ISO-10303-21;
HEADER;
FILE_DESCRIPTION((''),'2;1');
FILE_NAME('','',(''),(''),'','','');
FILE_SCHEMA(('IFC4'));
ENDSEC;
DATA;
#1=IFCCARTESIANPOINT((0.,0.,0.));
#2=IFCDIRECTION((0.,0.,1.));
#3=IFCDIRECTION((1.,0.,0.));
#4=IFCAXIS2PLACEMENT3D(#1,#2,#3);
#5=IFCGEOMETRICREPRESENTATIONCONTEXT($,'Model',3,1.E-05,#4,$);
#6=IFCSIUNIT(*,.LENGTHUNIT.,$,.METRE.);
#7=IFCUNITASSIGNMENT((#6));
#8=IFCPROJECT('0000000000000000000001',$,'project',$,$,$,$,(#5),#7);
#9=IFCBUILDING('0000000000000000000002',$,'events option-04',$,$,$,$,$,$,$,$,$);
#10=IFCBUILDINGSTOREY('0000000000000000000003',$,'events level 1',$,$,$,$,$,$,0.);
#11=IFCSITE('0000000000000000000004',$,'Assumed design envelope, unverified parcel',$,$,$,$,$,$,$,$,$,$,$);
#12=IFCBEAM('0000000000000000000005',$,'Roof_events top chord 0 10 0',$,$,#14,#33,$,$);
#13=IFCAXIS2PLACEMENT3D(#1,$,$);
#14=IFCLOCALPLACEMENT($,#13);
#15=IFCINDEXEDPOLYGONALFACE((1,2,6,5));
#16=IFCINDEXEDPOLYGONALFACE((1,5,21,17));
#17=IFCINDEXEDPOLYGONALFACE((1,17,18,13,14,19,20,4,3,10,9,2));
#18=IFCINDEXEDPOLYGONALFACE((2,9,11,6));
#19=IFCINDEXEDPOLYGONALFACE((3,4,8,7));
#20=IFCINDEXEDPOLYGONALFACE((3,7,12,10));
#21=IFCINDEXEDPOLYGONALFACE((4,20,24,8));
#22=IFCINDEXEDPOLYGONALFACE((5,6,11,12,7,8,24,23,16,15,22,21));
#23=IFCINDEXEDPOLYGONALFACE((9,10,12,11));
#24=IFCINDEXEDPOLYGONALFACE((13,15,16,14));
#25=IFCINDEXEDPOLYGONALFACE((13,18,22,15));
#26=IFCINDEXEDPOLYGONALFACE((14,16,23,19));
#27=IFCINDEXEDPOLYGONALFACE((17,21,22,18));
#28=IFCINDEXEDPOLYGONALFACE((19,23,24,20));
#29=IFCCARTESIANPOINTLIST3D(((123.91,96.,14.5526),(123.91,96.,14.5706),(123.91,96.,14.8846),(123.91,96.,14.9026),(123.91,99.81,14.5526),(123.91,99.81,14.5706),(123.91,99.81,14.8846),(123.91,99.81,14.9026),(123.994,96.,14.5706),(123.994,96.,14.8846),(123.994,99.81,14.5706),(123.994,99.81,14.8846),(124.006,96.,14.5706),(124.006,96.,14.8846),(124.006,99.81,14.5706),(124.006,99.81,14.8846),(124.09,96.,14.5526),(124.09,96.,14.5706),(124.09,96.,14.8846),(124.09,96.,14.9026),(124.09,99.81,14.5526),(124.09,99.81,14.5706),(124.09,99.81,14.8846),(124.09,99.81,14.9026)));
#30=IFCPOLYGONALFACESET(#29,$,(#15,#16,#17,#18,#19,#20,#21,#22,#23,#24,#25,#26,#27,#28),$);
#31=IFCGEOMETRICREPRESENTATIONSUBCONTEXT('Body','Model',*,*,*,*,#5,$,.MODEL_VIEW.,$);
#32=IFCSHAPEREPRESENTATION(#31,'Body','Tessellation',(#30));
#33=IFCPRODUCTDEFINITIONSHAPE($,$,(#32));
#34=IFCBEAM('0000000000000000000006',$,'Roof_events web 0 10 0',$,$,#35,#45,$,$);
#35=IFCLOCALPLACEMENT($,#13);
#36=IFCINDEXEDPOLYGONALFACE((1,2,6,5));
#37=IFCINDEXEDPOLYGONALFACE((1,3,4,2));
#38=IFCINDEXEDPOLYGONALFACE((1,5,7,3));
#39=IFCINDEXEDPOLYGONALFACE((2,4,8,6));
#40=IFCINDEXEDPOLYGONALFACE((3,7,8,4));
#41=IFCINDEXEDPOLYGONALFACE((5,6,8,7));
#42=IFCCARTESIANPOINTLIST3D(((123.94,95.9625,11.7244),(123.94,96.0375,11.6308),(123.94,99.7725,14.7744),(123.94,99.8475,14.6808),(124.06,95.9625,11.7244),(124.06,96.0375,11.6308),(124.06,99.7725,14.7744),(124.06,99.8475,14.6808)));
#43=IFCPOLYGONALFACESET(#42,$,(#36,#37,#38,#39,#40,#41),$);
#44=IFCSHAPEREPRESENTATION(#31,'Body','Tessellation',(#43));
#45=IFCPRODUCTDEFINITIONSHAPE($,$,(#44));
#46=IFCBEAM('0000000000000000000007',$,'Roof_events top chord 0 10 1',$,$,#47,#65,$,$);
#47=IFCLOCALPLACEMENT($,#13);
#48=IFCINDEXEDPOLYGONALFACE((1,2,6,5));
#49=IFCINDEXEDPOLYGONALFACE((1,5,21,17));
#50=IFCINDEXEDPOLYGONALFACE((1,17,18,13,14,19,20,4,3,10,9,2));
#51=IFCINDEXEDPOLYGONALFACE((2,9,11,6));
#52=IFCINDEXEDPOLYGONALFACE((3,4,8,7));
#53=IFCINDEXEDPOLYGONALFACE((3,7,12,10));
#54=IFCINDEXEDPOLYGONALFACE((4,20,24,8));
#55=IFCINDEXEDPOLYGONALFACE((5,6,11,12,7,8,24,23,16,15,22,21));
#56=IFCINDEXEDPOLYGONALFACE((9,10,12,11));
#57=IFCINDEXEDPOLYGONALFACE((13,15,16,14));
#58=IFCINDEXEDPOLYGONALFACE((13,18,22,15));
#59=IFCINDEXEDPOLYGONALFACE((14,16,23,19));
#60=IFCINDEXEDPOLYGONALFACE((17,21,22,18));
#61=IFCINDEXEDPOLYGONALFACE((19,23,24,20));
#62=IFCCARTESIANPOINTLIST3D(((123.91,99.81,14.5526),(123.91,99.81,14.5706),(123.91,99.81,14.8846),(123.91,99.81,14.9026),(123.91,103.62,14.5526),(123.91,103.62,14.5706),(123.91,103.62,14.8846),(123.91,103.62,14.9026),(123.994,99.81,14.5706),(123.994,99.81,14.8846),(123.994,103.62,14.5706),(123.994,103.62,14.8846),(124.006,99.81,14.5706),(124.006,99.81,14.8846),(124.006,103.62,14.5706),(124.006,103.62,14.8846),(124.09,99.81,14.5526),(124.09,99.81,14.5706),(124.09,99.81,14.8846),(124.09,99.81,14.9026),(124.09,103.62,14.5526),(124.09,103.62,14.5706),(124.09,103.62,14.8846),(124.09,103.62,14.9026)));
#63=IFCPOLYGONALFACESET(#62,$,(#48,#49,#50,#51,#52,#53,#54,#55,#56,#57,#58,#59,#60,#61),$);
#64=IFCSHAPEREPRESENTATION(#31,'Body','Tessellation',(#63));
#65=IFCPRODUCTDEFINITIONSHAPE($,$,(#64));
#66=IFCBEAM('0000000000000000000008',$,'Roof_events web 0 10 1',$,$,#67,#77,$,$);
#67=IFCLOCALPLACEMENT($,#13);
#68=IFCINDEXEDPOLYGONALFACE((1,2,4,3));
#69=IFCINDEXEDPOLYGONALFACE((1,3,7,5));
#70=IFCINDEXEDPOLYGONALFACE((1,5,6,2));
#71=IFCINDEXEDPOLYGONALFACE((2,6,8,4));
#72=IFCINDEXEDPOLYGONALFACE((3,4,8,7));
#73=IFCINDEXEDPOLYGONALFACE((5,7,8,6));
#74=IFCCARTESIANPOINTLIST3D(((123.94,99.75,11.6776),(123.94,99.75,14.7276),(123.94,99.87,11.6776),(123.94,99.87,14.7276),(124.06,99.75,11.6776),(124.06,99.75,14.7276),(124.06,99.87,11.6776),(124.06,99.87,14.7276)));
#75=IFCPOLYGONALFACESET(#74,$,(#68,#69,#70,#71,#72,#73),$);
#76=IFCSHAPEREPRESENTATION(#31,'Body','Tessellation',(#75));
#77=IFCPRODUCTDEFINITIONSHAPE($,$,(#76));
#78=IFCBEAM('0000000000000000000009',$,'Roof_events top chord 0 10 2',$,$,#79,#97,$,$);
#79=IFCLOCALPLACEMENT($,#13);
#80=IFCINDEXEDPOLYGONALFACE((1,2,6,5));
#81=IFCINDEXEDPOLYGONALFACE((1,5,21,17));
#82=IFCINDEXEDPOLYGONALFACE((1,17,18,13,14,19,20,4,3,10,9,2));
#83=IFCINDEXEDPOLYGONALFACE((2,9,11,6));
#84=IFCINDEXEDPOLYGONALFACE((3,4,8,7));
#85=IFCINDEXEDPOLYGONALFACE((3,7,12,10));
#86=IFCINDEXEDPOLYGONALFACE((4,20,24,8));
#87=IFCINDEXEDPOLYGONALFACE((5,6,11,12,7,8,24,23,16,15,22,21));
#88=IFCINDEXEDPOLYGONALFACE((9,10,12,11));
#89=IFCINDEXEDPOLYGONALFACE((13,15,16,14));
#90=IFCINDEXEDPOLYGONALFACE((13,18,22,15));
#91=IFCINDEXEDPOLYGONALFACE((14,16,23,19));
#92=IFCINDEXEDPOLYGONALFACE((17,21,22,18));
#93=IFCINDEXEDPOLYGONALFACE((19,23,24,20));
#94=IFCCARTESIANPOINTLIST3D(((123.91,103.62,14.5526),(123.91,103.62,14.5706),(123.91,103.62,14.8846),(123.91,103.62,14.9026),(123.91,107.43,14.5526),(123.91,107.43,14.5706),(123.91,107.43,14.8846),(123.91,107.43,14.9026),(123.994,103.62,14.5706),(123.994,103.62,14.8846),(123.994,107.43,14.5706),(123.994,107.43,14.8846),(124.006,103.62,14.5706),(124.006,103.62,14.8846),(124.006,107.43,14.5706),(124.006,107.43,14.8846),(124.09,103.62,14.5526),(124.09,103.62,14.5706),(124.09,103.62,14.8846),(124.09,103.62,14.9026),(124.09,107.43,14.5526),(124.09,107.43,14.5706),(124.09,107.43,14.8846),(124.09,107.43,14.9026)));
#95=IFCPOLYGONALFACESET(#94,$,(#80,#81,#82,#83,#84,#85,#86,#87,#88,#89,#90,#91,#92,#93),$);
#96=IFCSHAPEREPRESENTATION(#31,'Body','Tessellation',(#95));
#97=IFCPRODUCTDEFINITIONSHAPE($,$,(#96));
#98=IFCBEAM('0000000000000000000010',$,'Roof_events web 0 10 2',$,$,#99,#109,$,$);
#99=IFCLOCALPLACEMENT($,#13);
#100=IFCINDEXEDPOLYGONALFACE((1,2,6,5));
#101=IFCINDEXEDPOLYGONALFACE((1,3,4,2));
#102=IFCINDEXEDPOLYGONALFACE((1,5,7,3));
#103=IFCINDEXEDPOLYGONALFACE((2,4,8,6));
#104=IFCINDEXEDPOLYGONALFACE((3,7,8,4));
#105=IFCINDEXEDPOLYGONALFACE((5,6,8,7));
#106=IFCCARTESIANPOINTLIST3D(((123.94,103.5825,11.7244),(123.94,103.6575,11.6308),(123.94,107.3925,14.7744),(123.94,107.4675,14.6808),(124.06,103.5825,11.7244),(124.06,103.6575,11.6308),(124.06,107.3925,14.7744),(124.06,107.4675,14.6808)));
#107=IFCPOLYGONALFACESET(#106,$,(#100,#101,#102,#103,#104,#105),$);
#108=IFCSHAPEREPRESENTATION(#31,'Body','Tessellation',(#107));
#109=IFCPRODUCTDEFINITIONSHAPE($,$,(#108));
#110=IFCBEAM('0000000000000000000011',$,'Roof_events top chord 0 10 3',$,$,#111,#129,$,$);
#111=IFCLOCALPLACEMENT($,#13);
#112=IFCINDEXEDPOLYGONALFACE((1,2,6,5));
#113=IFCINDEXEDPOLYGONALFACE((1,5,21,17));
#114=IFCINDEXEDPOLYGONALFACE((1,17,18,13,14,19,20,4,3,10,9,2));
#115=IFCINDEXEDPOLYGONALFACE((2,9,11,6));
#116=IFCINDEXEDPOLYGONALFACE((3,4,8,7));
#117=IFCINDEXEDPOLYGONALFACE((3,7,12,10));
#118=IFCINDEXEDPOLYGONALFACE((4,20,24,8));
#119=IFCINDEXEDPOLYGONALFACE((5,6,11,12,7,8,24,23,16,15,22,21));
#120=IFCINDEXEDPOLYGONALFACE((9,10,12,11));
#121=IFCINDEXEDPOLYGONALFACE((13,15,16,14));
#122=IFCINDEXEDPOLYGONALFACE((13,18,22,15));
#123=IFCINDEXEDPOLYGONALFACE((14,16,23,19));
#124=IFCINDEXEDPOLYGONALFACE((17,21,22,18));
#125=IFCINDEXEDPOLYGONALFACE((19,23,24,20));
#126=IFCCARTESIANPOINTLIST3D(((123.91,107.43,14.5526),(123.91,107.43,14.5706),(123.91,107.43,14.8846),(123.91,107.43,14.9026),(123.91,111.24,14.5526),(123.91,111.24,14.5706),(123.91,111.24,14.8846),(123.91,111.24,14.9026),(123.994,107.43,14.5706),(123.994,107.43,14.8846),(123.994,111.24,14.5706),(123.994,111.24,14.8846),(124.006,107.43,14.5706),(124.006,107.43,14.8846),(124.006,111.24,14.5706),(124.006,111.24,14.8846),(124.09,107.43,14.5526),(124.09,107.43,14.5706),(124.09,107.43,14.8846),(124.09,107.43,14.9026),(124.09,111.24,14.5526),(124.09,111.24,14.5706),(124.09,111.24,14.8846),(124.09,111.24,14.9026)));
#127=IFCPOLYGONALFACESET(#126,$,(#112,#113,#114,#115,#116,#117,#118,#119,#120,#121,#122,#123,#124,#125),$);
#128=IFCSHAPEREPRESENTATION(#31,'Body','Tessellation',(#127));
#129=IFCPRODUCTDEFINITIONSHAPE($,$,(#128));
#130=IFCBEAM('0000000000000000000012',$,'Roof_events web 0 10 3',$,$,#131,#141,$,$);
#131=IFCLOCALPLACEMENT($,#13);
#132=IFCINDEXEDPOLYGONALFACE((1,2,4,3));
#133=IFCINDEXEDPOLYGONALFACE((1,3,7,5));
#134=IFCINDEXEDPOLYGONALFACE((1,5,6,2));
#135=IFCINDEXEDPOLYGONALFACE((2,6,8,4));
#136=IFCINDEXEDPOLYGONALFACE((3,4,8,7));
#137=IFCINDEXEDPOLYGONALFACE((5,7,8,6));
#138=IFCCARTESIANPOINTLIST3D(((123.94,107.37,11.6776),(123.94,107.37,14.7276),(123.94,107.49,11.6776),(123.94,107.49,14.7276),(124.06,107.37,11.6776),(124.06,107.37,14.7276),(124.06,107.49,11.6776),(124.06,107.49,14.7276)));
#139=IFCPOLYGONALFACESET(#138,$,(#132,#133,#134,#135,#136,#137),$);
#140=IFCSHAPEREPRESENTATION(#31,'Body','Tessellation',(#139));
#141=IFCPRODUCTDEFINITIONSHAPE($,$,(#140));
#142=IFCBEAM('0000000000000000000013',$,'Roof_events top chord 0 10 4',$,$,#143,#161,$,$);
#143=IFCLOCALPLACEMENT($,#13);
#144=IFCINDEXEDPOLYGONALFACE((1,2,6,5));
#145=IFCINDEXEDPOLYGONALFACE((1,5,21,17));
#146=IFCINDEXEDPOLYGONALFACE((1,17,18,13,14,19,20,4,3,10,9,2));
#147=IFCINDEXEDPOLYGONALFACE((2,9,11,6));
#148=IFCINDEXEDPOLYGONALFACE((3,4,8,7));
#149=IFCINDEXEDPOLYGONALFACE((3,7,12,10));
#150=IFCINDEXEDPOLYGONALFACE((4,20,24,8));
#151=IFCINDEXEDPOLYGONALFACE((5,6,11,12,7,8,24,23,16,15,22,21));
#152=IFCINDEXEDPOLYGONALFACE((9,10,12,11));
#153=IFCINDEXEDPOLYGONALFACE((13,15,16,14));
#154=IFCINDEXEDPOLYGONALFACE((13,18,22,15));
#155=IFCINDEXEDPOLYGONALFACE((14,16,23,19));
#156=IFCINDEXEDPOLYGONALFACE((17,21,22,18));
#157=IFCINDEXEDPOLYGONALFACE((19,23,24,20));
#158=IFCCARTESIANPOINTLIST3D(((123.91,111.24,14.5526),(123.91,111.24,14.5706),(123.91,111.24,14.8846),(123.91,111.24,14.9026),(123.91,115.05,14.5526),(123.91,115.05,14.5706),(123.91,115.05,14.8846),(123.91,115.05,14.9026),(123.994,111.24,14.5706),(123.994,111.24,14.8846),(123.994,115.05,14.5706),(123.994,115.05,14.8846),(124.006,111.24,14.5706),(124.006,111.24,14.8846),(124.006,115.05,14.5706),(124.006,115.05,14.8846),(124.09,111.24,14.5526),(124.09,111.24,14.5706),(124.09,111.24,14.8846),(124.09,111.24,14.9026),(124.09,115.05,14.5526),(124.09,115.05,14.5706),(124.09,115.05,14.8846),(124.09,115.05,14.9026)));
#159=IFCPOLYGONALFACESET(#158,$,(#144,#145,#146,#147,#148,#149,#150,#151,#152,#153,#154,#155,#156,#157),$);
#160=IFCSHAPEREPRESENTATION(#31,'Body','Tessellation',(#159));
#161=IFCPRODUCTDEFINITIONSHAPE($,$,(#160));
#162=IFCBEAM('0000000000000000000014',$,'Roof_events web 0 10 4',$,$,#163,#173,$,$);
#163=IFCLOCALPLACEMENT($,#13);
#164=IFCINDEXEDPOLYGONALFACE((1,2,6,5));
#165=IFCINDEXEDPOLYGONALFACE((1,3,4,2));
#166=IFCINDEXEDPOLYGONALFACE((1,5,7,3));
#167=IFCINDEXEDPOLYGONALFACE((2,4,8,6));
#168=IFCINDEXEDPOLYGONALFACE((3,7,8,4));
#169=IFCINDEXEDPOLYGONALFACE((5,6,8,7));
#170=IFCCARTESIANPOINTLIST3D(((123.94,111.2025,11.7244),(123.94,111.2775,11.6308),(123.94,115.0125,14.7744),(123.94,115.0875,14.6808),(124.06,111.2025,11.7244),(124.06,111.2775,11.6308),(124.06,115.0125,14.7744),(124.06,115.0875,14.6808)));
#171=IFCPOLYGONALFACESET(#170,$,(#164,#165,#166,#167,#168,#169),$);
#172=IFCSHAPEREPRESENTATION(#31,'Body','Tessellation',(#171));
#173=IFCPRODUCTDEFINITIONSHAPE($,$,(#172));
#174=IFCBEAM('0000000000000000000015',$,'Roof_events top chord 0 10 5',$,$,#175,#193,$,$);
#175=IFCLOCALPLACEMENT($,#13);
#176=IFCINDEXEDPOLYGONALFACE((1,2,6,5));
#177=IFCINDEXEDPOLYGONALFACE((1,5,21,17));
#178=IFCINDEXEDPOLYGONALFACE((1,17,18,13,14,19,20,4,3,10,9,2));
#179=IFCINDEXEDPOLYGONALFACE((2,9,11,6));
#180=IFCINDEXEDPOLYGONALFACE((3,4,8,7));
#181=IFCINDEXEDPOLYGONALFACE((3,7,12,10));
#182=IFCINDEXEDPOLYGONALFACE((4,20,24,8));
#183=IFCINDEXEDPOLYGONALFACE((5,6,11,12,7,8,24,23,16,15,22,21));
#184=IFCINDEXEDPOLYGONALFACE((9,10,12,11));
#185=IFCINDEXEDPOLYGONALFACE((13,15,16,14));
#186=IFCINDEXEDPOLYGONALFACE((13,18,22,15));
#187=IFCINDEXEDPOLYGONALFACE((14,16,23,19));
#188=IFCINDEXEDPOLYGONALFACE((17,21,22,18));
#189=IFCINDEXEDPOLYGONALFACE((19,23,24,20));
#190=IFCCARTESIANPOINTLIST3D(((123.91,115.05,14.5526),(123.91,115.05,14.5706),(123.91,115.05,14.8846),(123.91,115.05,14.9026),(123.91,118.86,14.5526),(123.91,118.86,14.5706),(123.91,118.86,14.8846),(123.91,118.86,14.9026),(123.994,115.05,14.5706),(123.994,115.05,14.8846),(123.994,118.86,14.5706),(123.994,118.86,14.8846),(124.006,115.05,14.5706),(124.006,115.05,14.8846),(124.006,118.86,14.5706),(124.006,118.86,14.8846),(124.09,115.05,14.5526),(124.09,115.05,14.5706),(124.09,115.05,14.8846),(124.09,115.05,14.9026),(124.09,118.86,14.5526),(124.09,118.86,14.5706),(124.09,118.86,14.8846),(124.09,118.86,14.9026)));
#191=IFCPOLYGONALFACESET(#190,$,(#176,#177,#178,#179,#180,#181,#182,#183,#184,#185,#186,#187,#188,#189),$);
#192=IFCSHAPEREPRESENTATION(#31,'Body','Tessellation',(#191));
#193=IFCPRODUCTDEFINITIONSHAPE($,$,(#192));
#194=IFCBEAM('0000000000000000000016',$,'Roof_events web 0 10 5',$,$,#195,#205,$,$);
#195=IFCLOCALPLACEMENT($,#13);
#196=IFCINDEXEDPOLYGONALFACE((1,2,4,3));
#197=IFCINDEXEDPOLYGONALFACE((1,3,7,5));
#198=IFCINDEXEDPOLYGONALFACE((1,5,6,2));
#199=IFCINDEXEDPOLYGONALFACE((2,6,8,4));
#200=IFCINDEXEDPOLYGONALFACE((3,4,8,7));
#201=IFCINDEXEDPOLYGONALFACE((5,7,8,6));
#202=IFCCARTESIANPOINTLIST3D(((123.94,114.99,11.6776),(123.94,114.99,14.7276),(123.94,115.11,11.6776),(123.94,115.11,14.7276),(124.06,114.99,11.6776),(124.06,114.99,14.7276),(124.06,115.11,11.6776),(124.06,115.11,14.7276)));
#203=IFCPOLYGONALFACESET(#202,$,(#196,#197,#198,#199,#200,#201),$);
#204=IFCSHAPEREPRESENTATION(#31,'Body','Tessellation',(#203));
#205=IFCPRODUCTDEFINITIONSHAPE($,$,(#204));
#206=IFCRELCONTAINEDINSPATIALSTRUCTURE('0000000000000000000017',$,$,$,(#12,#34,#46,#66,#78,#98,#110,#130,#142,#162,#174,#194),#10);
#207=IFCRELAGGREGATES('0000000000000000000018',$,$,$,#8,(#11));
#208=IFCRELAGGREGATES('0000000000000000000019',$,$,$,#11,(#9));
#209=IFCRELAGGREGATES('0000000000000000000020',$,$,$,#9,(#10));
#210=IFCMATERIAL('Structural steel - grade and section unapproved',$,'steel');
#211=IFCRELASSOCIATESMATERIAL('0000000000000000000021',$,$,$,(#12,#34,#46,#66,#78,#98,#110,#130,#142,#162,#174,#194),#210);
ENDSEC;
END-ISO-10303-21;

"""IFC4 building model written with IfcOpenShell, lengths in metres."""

from ifc_helpers import new_model, si_unit, frame, origin_with_axes, place, context, subcontext, project, spatial, rectangle, i_section, extrude, material, element, save


model = new_model("IFC4")

# Units and contexts
model_context = context("Model", 3, precision=1e-05, world=origin_with_axes())
body_context = subcontext(model_context, "Body", "Model", "MODEL_VIEW")
ifc_project = project(units=[si_unit("LENGTHUNIT", "METRE")], contexts=[model_context])

# Site, building, storey
site = spatial("IfcSite", under=ifc_project, Name="Assumed design envelope, unverified parcel")
building = spatial("IfcBuilding", under=site, Name="events option-04")
storey = spatial("IfcBuildingStorey", under=building, Name="events level 1", Elevation=0.0)

# Shared definitions
ifc_material_1 = material(Name="Structural steel - grade and section unapproved", Category="steel")

# Beams
beam_1_placement = place(None, frame((124.0, 96.0, 14.7276), z_axis=(0.0, 1.0, 0.0), x_axis=(-1.0, 0.0, 0.0)))
element("IfcBeam", 1, at=beam_1_placement, inside=storey, material=ifc_material_1, Name="Roof_events top chord 0 10 0", context=body_context, shape_type="SweptSolid", body=[
    extrude(i_section(OverallWidth=0.18, OverallDepth=0.35, WebThickness=0.012, FlangeThickness=0.018, FilletRadius=0.0), origin_with_axes(), (0.0, 0.0, 1.0), 3.81),
])
beam_2_placement = place(None, frame((124.0, 96.0, 11.6776), z_axis=(0.0, 0.780669, 0.624945), x_axis=(-1.0, 0.0, 0.0)))
element("IfcBeam", 2, at=beam_2_placement, inside=storey, material=ifc_material_1, Name="Roof_events web 0 10 0", context=body_context, shape_type="SweptSolid", body=[
    extrude(rectangle(XDim=0.12, YDim=0.12), origin_with_axes(), (0.0, 0.0, 1.0), 4.8804),
])
beam_3_placement = place(None, frame((124.0, 99.81, 14.7276), z_axis=(0.0, 1.0, 0.0), x_axis=(-1.0, 0.0, 0.0)))
element("IfcBeam", 3, at=beam_3_placement, inside=storey, material=ifc_material_1, Name="Roof_events top chord 0 10 1", context=body_context, shape_type="SweptSolid", body=[
    extrude(i_section(OverallWidth=0.18, OverallDepth=0.35, WebThickness=0.012, FlangeThickness=0.018, FilletRadius=0.0), origin_with_axes(), (0.0, 0.0, 1.0), 3.81),
])
beam_4_placement = place(None, frame((124.0, 99.81, 11.6776), z_axis=(0.0, 0.0, 1.0), x_axis=(-1.0, 0.0, 0.0)))
element("IfcBeam", 4, at=beam_4_placement, inside=storey, material=ifc_material_1, Name="Roof_events web 0 10 1", context=body_context, shape_type="SweptSolid", body=[
    extrude(rectangle(XDim=0.12, YDim=0.12), origin_with_axes(), (0.0, 0.0, 1.0), 3.05),
])
beam_5_placement = place(None, frame((124.0, 103.62, 14.7276), z_axis=(0.0, 1.0, 0.0), x_axis=(-1.0, 0.0, 0.0)))
element("IfcBeam", 5, at=beam_5_placement, inside=storey, material=ifc_material_1, Name="Roof_events top chord 0 10 2", context=body_context, shape_type="SweptSolid", body=[
    extrude(i_section(OverallWidth=0.18, OverallDepth=0.35, WebThickness=0.012, FlangeThickness=0.018, FilletRadius=0.0), origin_with_axes(), (0.0, 0.0, 1.0), 3.81),
])
beam_6_placement = place(None, frame((124.0, 103.62, 11.6776), z_axis=(0.0, 0.780669, 0.624945), x_axis=(-1.0, 0.0, 0.0)))
element("IfcBeam", 6, at=beam_6_placement, inside=storey, material=ifc_material_1, Name="Roof_events web 0 10 2", context=body_context, shape_type="SweptSolid", body=[
    extrude(rectangle(XDim=0.12, YDim=0.12), origin_with_axes(), (0.0, 0.0, 1.0), 4.8804),
])
beam_7_placement = place(None, frame((124.0, 107.43, 14.7276), z_axis=(0.0, 1.0, 0.0), x_axis=(-1.0, 0.0, 0.0)))
element("IfcBeam", 7, at=beam_7_placement, inside=storey, material=ifc_material_1, Name="Roof_events top chord 0 10 3", context=body_context, shape_type="SweptSolid", body=[
    extrude(i_section(OverallWidth=0.18, OverallDepth=0.35, WebThickness=0.012, FlangeThickness=0.018, FilletRadius=0.0), origin_with_axes(), (0.0, 0.0, 1.0), 3.81),
])
beam_8_placement = place(None, frame((124.0, 107.43, 11.6776), z_axis=(0.0, 0.0, 1.0), x_axis=(-1.0, 0.0, 0.0)))
element("IfcBeam", 8, at=beam_8_placement, inside=storey, material=ifc_material_1, Name="Roof_events web 0 10 3", context=body_context, shape_type="SweptSolid", body=[
    extrude(rectangle(XDim=0.12, YDim=0.12), origin_with_axes(), (0.0, 0.0, 1.0), 3.05),
])
beam_9_placement = place(None, frame((124.0, 111.24, 14.7276), z_axis=(0.0, 1.0, 0.0), x_axis=(-1.0, 0.0, 0.0)))
element("IfcBeam", 9, at=beam_9_placement, inside=storey, material=ifc_material_1, Name="Roof_events top chord 0 10 4", context=body_context, shape_type="SweptSolid", body=[
    extrude(i_section(OverallWidth=0.18, OverallDepth=0.35, WebThickness=0.012, FlangeThickness=0.018, FilletRadius=0.0), origin_with_axes(), (0.0, 0.0, 1.0), 3.81),
])
beam_10_placement = place(None, frame((124.0, 111.24, 11.6776), z_axis=(0.0, 0.780669, 0.624944), x_axis=(-1.0, 0.0, 0.0)))
element("IfcBeam", 10, at=beam_10_placement, inside=storey, material=ifc_material_1, Name="Roof_events web 0 10 4", context=body_context, shape_type="SweptSolid", body=[
    extrude(rectangle(XDim=0.12, YDim=0.12), origin_with_axes(), (0.0, 0.0, 1.0), 4.8804),
])
beam_11_placement = place(None, frame((124.0, 115.05, 14.7276), z_axis=(0.0, 1.0, 0.0), x_axis=(-1.0, 0.0, 0.0)))
element("IfcBeam", 11, at=beam_11_placement, inside=storey, material=ifc_material_1, Name="Roof_events top chord 0 10 5", context=body_context, shape_type="SweptSolid", body=[
    extrude(i_section(OverallWidth=0.18, OverallDepth=0.35, WebThickness=0.012, FlangeThickness=0.018, FilletRadius=0.0), origin_with_axes(), (0.0, 0.0, 1.0), 3.81),
])
beam_12_placement = place(None, frame((124.0, 115.05, 11.6776), z_axis=(0.0, 0.0, 1.0), x_axis=(-1.0, 0.0, 0.0)))
element("IfcBeam", 12, at=beam_12_placement, inside=storey, material=ifc_material_1, Name="Roof_events web 0 10 5", context=body_context, shape_type="SweptSolid", body=[
    extrude(rectangle(XDim=0.12, YDim=0.12), origin_with_axes(), (0.0, 0.0, 1.0), 3.05),
])

save(model, "model.ifc")
